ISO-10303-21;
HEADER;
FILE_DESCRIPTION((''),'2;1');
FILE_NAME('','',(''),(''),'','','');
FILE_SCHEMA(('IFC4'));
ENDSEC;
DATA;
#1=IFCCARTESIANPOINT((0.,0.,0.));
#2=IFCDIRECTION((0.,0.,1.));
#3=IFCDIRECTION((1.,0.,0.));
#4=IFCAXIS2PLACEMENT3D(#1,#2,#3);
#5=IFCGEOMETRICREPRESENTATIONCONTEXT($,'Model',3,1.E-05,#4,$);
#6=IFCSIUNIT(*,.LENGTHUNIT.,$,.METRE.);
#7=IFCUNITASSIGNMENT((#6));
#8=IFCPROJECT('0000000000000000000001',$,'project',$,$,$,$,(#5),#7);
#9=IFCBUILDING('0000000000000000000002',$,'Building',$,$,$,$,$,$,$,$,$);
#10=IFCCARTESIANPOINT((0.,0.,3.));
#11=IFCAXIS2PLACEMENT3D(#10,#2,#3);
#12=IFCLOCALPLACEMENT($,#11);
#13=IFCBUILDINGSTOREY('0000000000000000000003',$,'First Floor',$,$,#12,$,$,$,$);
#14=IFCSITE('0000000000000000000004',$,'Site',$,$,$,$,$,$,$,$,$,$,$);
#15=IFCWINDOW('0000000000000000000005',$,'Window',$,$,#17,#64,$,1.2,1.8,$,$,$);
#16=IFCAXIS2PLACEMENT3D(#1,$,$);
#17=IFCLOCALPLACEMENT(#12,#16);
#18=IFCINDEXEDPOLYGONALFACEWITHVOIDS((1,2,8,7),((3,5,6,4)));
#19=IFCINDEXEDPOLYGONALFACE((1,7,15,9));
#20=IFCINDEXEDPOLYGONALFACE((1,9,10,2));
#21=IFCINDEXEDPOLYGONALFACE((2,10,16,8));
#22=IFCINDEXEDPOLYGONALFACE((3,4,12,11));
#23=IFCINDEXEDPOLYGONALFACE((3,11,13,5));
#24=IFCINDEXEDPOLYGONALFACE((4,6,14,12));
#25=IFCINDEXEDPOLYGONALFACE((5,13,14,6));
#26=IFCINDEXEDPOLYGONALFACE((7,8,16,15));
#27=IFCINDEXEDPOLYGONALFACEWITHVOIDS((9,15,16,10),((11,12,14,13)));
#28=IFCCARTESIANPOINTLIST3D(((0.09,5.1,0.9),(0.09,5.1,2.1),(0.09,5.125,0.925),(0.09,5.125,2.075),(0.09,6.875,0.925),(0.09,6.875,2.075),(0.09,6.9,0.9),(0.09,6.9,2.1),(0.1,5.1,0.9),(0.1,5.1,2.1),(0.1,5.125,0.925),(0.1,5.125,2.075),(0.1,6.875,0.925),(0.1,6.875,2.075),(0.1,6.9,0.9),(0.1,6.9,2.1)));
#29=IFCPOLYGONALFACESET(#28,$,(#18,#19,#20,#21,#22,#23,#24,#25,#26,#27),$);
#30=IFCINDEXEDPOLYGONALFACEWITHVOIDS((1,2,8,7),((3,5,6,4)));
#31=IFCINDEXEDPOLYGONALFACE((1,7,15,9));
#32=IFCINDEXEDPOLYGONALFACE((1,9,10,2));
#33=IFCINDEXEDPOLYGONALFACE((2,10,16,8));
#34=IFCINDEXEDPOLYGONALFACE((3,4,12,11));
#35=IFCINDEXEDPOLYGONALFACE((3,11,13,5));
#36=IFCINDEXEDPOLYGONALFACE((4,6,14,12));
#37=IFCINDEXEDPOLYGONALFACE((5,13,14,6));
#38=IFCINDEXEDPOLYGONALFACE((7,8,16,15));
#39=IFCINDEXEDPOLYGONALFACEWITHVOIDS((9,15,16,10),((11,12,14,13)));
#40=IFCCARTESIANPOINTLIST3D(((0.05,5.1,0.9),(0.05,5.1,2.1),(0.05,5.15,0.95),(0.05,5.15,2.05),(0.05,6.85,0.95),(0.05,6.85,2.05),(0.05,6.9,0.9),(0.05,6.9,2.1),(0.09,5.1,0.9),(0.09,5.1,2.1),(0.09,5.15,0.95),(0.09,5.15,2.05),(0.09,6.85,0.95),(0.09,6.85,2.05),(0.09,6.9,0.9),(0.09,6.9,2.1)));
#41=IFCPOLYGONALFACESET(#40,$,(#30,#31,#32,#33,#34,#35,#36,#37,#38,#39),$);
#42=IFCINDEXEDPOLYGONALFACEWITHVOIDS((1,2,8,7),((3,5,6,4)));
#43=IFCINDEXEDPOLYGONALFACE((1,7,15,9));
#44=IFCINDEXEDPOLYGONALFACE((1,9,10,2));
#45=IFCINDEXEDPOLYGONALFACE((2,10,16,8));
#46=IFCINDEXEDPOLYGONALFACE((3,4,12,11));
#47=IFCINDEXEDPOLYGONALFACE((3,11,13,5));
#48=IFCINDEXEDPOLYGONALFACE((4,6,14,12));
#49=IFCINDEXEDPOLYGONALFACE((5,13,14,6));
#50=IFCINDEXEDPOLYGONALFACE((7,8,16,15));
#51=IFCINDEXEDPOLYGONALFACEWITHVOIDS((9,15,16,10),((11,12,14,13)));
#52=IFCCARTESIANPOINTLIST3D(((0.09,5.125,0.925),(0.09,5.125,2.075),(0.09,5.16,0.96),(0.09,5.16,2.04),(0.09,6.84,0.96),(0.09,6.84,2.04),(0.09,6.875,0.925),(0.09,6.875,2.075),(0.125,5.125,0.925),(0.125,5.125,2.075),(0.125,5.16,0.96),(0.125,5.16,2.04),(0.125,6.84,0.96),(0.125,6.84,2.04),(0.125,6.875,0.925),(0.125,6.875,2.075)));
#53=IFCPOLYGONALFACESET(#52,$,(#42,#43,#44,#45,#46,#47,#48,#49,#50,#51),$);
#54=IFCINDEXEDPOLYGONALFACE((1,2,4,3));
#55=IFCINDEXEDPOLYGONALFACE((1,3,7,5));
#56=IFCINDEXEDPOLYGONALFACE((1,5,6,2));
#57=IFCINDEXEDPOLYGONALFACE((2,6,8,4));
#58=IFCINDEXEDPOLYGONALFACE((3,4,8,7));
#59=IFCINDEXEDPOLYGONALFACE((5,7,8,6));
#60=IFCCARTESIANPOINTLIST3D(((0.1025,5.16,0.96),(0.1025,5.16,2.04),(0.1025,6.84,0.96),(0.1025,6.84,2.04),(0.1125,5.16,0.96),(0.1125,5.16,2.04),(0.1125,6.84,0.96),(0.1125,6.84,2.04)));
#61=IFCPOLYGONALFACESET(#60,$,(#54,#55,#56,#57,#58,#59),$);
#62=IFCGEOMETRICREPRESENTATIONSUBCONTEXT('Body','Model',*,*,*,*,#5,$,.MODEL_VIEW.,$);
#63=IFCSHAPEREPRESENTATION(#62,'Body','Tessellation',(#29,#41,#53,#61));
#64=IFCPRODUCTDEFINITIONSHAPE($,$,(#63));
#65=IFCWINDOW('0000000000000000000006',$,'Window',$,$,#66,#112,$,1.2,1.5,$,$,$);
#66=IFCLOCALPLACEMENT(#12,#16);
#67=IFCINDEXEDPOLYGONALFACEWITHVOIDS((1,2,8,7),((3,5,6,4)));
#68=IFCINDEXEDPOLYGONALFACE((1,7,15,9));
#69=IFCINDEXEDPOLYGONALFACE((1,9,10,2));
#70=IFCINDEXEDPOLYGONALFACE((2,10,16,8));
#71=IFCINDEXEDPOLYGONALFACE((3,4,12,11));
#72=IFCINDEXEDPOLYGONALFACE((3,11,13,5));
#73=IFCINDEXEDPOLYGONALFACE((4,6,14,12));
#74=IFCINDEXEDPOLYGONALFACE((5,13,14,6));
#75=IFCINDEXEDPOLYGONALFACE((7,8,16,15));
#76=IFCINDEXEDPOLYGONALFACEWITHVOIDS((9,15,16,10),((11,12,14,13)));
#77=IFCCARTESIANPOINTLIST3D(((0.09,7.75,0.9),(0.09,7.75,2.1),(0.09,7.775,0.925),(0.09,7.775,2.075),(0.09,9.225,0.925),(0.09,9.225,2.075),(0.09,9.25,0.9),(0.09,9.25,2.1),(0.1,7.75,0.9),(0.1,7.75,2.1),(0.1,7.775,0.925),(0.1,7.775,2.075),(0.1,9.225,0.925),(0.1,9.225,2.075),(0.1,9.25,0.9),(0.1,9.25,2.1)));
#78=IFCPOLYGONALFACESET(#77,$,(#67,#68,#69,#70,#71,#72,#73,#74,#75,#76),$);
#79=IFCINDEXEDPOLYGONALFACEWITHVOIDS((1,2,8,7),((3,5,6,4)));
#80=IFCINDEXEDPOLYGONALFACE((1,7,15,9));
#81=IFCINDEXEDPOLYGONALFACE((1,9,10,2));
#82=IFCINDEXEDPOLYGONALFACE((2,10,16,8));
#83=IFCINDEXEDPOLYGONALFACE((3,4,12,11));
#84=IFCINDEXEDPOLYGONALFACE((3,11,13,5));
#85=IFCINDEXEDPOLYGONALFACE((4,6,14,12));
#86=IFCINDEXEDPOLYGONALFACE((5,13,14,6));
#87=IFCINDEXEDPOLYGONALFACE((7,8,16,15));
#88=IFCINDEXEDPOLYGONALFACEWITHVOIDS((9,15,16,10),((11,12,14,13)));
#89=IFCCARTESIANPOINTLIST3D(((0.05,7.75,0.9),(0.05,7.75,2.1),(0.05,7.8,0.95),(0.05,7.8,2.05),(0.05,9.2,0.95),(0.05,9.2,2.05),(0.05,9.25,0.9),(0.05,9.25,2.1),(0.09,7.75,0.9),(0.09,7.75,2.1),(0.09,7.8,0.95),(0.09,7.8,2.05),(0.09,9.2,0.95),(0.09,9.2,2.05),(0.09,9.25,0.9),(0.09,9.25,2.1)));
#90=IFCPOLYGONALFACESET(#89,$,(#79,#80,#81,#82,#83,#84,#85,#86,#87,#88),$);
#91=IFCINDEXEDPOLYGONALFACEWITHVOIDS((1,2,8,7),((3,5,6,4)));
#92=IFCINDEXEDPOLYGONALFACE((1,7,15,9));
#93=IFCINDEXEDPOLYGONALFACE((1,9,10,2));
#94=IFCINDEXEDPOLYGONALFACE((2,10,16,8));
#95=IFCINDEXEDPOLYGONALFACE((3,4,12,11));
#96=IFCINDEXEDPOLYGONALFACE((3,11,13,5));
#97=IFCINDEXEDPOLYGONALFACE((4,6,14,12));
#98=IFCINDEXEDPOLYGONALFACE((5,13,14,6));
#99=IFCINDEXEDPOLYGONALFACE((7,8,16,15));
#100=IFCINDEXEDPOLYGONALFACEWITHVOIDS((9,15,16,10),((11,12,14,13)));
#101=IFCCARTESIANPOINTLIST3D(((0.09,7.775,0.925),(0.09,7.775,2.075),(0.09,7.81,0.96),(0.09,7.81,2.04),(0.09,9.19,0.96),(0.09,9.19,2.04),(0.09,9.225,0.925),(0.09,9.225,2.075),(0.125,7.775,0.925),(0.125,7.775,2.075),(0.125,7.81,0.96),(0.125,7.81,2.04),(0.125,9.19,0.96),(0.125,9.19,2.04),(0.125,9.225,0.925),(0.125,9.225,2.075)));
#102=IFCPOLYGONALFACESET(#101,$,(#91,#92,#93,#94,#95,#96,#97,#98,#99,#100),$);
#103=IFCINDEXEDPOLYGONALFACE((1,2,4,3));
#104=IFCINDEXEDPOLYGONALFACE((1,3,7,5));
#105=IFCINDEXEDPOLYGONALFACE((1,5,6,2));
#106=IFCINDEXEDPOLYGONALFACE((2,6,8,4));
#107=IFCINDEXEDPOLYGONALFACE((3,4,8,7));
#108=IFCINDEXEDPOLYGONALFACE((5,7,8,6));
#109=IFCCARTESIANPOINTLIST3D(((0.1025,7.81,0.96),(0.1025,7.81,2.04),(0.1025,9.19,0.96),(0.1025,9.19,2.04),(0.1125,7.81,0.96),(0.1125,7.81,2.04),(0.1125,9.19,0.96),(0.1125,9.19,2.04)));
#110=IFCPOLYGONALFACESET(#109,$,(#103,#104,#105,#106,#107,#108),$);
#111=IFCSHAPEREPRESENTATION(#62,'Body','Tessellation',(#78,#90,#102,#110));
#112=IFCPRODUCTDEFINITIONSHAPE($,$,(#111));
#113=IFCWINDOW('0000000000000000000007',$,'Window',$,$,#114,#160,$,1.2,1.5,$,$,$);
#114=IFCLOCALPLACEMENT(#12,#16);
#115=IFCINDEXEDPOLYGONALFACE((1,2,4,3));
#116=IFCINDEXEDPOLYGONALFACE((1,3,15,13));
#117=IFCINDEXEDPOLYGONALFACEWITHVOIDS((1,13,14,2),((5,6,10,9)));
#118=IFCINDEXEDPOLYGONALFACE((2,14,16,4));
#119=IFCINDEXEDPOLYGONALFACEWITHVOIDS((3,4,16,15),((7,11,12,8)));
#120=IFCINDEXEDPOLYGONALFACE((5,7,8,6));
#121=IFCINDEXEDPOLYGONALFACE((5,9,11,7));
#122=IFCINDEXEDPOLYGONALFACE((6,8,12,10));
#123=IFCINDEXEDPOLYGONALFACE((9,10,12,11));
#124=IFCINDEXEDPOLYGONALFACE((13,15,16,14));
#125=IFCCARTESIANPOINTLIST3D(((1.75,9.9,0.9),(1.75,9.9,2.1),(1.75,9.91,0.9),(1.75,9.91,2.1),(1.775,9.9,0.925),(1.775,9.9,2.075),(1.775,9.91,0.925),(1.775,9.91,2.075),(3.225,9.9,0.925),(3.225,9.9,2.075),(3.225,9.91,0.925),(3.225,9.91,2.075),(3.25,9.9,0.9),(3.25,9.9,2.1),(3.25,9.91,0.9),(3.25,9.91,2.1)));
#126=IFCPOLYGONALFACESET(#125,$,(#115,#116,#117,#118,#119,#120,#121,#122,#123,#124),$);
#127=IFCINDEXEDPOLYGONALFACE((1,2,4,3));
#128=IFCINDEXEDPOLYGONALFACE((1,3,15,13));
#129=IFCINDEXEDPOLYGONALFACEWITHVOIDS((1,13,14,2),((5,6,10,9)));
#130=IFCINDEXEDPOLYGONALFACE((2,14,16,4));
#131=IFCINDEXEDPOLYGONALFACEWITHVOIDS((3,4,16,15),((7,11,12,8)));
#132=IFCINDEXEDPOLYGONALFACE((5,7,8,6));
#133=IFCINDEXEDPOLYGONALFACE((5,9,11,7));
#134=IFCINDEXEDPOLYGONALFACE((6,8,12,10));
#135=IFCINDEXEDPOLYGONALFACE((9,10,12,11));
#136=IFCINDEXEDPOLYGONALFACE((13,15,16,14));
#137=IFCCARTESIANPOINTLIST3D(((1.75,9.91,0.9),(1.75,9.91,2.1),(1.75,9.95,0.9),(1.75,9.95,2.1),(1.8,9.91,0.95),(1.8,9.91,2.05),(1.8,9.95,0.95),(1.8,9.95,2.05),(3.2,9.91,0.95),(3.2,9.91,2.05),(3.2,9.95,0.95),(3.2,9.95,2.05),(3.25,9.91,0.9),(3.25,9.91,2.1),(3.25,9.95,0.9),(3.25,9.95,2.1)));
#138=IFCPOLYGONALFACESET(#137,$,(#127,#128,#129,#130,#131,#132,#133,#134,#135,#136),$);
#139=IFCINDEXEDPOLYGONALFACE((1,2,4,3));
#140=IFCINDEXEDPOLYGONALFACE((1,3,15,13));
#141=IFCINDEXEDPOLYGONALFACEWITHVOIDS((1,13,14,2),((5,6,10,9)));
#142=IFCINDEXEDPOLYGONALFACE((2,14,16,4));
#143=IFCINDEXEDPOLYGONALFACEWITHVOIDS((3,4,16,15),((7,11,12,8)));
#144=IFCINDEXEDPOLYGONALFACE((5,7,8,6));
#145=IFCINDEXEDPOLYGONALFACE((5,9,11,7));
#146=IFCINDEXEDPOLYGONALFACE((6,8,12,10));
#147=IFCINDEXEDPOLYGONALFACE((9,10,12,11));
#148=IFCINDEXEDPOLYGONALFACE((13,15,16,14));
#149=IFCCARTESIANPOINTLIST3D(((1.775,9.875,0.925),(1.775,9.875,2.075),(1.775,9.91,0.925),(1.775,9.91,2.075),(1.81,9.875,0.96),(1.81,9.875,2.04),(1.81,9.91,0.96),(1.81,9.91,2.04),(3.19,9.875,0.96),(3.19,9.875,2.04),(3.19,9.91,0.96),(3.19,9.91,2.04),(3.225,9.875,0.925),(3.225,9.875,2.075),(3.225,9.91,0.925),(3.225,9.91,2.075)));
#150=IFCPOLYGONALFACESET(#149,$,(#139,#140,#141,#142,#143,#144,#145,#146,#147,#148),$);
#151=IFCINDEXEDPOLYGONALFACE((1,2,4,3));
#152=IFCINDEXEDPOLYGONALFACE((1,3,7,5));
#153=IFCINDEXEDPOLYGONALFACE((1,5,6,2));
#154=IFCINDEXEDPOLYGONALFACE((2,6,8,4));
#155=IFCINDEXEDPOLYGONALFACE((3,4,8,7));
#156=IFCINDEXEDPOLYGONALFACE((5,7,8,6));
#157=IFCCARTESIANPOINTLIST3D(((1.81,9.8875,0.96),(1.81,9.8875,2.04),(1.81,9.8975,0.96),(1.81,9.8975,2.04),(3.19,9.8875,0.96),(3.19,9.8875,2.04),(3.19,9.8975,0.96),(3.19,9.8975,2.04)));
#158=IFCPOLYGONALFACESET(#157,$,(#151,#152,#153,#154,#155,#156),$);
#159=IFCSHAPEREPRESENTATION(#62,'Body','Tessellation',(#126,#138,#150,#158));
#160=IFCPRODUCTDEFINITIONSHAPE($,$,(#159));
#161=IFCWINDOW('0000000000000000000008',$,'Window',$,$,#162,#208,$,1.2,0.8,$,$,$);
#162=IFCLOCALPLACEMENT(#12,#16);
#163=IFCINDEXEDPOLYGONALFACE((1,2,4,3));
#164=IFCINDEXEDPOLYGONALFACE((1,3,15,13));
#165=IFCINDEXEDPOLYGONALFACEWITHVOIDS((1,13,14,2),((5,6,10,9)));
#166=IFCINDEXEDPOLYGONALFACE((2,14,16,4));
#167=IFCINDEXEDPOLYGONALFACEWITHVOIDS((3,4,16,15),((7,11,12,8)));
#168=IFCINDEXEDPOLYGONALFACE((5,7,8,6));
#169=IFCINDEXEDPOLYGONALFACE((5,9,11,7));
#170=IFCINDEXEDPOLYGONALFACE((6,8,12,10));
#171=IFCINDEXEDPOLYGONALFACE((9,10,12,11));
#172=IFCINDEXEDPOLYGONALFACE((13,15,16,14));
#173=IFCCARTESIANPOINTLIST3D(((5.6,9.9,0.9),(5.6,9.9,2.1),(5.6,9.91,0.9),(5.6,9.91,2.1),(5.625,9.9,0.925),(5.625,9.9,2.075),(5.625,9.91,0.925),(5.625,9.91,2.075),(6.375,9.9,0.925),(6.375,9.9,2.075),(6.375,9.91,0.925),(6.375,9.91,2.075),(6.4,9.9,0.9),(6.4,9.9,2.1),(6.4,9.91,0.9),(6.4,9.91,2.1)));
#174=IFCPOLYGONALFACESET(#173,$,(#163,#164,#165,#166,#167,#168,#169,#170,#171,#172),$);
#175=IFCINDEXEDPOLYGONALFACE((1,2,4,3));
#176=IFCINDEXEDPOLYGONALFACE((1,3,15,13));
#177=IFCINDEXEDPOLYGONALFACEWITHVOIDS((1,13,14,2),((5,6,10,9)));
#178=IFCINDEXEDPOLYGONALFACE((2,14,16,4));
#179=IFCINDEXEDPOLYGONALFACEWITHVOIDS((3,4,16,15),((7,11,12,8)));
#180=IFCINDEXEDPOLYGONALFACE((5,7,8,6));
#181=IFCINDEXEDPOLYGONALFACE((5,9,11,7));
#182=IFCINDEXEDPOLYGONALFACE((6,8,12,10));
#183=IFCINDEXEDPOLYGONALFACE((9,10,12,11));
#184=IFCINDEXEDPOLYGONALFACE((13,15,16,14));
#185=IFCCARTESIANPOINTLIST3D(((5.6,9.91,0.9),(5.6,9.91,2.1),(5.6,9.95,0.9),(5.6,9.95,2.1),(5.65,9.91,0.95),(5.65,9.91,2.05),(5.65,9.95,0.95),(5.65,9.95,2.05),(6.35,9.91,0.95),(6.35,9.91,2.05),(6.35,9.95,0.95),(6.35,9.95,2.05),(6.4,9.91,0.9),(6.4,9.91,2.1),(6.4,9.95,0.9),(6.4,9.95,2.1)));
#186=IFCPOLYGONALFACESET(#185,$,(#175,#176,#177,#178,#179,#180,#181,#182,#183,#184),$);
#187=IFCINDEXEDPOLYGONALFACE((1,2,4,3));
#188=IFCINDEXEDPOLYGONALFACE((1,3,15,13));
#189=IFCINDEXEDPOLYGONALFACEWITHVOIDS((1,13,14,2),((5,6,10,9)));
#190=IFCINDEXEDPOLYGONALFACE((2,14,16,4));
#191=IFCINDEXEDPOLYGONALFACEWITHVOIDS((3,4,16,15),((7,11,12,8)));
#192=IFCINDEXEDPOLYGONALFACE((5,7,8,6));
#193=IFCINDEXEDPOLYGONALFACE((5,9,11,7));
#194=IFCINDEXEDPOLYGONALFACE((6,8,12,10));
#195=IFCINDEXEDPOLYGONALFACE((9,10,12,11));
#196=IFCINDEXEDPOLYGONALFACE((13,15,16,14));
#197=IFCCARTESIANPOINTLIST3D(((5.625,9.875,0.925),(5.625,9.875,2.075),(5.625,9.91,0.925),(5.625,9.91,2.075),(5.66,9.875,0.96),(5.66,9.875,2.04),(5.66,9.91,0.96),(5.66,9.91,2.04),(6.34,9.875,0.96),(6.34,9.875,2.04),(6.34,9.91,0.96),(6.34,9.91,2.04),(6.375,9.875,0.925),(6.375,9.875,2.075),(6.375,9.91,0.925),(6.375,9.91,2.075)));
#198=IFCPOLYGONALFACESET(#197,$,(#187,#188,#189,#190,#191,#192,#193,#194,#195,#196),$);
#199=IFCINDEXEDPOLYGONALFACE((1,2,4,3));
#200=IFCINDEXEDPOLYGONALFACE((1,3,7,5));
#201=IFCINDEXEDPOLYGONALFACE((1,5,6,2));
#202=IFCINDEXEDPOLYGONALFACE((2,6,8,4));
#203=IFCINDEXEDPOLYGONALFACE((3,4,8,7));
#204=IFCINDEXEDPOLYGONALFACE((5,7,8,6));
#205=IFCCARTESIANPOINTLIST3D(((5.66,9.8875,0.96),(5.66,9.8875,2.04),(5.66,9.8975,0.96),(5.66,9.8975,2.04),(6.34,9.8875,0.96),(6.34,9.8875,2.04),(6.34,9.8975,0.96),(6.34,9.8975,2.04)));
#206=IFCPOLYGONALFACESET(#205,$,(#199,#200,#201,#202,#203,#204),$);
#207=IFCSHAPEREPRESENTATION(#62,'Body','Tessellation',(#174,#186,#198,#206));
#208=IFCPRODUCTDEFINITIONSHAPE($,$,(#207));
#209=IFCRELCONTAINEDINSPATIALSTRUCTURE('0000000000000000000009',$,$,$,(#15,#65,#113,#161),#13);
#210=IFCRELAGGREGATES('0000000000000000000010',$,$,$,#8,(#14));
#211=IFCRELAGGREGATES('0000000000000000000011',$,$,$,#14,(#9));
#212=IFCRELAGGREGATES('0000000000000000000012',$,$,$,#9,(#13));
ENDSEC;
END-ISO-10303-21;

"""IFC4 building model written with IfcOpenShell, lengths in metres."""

from ifc_helpers import new_model, si_unit, frame, origin_with_axes, place, context, subcontext, project, spatial, line, indexed_curve, outline, extrude, element, save


model = new_model("IFC4")

# Units and contexts
model_context = context("Model", 3, precision=1e-05, world=origin_with_axes())
body_context = subcontext(model_context, "Body", "Model", "MODEL_VIEW")
ifc_project = project(units=[si_unit("LENGTHUNIT", "METRE")], contexts=[model_context])

# Site, building, storey
site = spatial("IfcSite", under=ifc_project, Name="Site")
building = spatial("IfcBuilding", under=site, Name="Building")
storey_placement = place(None, frame((0.0, 0.0, 3.0), z_axis=(0.0, 0.0, 1.0), x_axis=(1.0, 0.0, 0.0)))
storey = spatial("IfcBuildingStorey", under=building, at=storey_placement, Name="First Floor")

# Windows
for number, where, z_axis, x_axis, name in (
    (1, (0.0, 6.9, 0.9), (0.0, 0.0, 1.0), (0.0, -1.0, 0.0), "Window"),
):
    element("IfcWindow", number, at=place(storey_placement, frame(where, z_axis=z_axis, x_axis=x_axis)), inside=storey, Name=name, OverallHeight=1.2, OverallWidth=1.8, context=body_context, shape_type="SweptSolid", body=[
        extrude(outline(indexed_curve([(0.0, 0.0), (1.8, 0.0), (1.8, 1.2), (0.0, 1.2)], segments=[line(1, 2, 3, 4, 1)]), holes=[indexed_curve([(0.025, 0.025), (1.775, 0.025), (1.775, 1.175), (0.025, 1.175)], segments=[line(1, 2, 3, 4, 1)])]), frame((0.0, 0.09, 0.0), z_axis=(0.0, -1.0, 0.0), x_axis=(1.0, 0.0, 0.0)), (0.0, 0.0, -1.0), 0.01),
        extrude(outline(indexed_curve([(0.0, 0.0), (1.8, 0.0), (1.8, 1.2), (0.0, 1.2)], segments=[line(1, 2, 3, 4, 1)]), holes=[indexed_curve([(0.05, 0.05), (1.75, 0.05), (1.75, 1.15), (0.05, 1.15)], segments=[line(1, 2, 3, 4, 1)])]), frame((0.0, 0.05, 0.0), z_axis=(0.0, -1.0, 0.0), x_axis=(1.0, 0.0, 0.0)), (0.0, 0.0, -1.0), 0.04),
        extrude(outline(indexed_curve([(0.0, 0.0), (1.75, 0.0), (1.75, 1.15), (0.0, 1.15)], segments=[line(1, 2, 3, 4, 1)]), holes=[indexed_curve([(0.035, 0.035), (1.715, 0.035), (1.715, 1.115), (0.035, 1.115)], segments=[line(1, 2, 3, 4, 1)])]), frame((0.025, 0.09, 0.025), z_axis=(0.0, -1.0, 0.0), x_axis=(1.0, 0.0, 0.0)), (0.0, 0.0, -1.0), 0.035),
        extrude(outline(indexed_curve([(0.035, 0.035), (1.715, 0.035), (1.715, 1.115), (0.035, 1.115)], segments=[line(1, 2, 3, 4, 1)])), frame((0.025, 0.1025, 0.025), z_axis=(0.0, -1.0, 0.0), x_axis=(1.0, 0.0, 0.0)), (0.0, 0.0, -1.0), 0.01),
    ])
for number, where, z_axis, x_axis, name in (
    (2, (0.0, 9.25, 0.9), (0.0, 0.0, 1.0), (0.0, -1.0, 0.0), "Window"),
    (3, (3.25, 10.0, 0.9), (0.0, 0.0, 1.0), (-1.0, 0.0, 0.0), "Window"),
):
    element("IfcWindow", number, at=place(storey_placement, frame(where, z_axis=z_axis, x_axis=x_axis)), inside=storey, Name=name, OverallHeight=1.2, OverallWidth=1.5, context=body_context, shape_type="SweptSolid", body=[
        extrude(outline(indexed_curve([(0.0, 0.0), (1.5, 0.0), (1.5, 1.2), (0.0, 1.2)], segments=[line(1, 2, 3, 4, 1)]), holes=[indexed_curve([(0.025, 0.025), (1.475, 0.025), (1.475, 1.175), (0.025, 1.175)], segments=[line(1, 2, 3, 4, 1)])]), frame((0.0, 0.09, 0.0), z_axis=(0.0, -1.0, 0.0), x_axis=(1.0, 0.0, 0.0)), (0.0, 0.0, -1.0), 0.01),
        extrude(outline(indexed_curve([(0.0, 0.0), (1.5, 0.0), (1.5, 1.2), (0.0, 1.2)], segments=[line(1, 2, 3, 4, 1)]), holes=[indexed_curve([(0.05, 0.05), (1.45, 0.05), (1.45, 1.15), (0.05, 1.15)], segments=[line(1, 2, 3, 4, 1)])]), frame((0.0, 0.05, 0.0), z_axis=(0.0, -1.0, 0.0), x_axis=(1.0, 0.0, 0.0)), (0.0, 0.0, -1.0), 0.04),
        extrude(outline(indexed_curve([(0.0, 0.0), (1.45, 0.0), (1.45, 1.15), (0.0, 1.15)], segments=[line(1, 2, 3, 4, 1)]), holes=[indexed_curve([(0.035, 0.035), (1.415, 0.035), (1.415, 1.115), (0.035, 1.115)], segments=[line(1, 2, 3, 4, 1)])]), frame((0.025, 0.09, 0.025), z_axis=(0.0, -1.0, 0.0), x_axis=(1.0, 0.0, 0.0)), (0.0, 0.0, -1.0), 0.035),
        extrude(outline(indexed_curve([(0.035, 0.035), (1.415, 0.035), (1.415, 1.115), (0.035, 1.115)], segments=[line(1, 2, 3, 4, 1)])), frame((0.025, 0.1025, 0.025), z_axis=(0.0, -1.0, 0.0), x_axis=(1.0, 0.0, 0.0)), (0.0, 0.0, -1.0), 0.01),
    ])
window_1_placement = place(storey_placement, frame((6.4, 10.0, 0.9), z_axis=(0.0, 0.0, 1.0), x_axis=(-1.0, 0.0, 0.0)))
element("IfcWindow", 4, at=window_1_placement, inside=storey, Name="Window", OverallHeight=1.2, OverallWidth=0.8, context=body_context, shape_type="SweptSolid", body=[
    extrude(outline(indexed_curve([(0.0, 0.0), (0.8, 0.0), (0.8, 1.2), (0.0, 1.2)], segments=[line(1, 2, 3, 4, 1)]), holes=[indexed_curve([(0.025, 0.025), (0.775, 0.025), (0.775, 1.175), (0.025, 1.175)], segments=[line(1, 2, 3, 4, 1)])]), frame((0.0, 0.09, 0.0), z_axis=(0.0, -1.0, 0.0), x_axis=(1.0, 0.0, 0.0)), (0.0, 0.0, -1.0), 0.01),
    extrude(outline(indexed_curve([(0.0, 0.0), (0.8, 0.0), (0.8, 1.2), (0.0, 1.2)], segments=[line(1, 2, 3, 4, 1)]), holes=[indexed_curve([(0.05, 0.05), (0.75, 0.05), (0.75, 1.15), (0.05, 1.15)], segments=[line(1, 2, 3, 4, 1)])]), frame((0.0, 0.05, 0.0), z_axis=(0.0, -1.0, 0.0), x_axis=(1.0, 0.0, 0.0)), (0.0, 0.0, -1.0), 0.04),
    extrude(outline(indexed_curve([(0.0, 0.0), (0.75, 0.0), (0.75, 1.15), (0.0, 1.15)], segments=[line(1, 2, 3, 4, 1)]), holes=[indexed_curve([(0.035, 0.035), (0.715, 0.035), (0.715, 1.115), (0.035, 1.115)], segments=[line(1, 2, 3, 4, 1)])]), frame((0.025, 0.09, 0.025), z_axis=(0.0, -1.0, 0.0), x_axis=(1.0, 0.0, 0.0)), (0.0, 0.0, -1.0), 0.035),
    extrude(outline(indexed_curve([(0.035, 0.035), (0.715, 0.035), (0.715, 1.115), (0.035, 1.115)], segments=[line(1, 2, 3, 4, 1)])), frame((0.025, 0.1025, 0.025), z_axis=(0.0, -1.0, 0.0), x_axis=(1.0, 0.0, 0.0)), (0.0, 0.0, -1.0), 0.01),
])

save(model, "model.ifc")
